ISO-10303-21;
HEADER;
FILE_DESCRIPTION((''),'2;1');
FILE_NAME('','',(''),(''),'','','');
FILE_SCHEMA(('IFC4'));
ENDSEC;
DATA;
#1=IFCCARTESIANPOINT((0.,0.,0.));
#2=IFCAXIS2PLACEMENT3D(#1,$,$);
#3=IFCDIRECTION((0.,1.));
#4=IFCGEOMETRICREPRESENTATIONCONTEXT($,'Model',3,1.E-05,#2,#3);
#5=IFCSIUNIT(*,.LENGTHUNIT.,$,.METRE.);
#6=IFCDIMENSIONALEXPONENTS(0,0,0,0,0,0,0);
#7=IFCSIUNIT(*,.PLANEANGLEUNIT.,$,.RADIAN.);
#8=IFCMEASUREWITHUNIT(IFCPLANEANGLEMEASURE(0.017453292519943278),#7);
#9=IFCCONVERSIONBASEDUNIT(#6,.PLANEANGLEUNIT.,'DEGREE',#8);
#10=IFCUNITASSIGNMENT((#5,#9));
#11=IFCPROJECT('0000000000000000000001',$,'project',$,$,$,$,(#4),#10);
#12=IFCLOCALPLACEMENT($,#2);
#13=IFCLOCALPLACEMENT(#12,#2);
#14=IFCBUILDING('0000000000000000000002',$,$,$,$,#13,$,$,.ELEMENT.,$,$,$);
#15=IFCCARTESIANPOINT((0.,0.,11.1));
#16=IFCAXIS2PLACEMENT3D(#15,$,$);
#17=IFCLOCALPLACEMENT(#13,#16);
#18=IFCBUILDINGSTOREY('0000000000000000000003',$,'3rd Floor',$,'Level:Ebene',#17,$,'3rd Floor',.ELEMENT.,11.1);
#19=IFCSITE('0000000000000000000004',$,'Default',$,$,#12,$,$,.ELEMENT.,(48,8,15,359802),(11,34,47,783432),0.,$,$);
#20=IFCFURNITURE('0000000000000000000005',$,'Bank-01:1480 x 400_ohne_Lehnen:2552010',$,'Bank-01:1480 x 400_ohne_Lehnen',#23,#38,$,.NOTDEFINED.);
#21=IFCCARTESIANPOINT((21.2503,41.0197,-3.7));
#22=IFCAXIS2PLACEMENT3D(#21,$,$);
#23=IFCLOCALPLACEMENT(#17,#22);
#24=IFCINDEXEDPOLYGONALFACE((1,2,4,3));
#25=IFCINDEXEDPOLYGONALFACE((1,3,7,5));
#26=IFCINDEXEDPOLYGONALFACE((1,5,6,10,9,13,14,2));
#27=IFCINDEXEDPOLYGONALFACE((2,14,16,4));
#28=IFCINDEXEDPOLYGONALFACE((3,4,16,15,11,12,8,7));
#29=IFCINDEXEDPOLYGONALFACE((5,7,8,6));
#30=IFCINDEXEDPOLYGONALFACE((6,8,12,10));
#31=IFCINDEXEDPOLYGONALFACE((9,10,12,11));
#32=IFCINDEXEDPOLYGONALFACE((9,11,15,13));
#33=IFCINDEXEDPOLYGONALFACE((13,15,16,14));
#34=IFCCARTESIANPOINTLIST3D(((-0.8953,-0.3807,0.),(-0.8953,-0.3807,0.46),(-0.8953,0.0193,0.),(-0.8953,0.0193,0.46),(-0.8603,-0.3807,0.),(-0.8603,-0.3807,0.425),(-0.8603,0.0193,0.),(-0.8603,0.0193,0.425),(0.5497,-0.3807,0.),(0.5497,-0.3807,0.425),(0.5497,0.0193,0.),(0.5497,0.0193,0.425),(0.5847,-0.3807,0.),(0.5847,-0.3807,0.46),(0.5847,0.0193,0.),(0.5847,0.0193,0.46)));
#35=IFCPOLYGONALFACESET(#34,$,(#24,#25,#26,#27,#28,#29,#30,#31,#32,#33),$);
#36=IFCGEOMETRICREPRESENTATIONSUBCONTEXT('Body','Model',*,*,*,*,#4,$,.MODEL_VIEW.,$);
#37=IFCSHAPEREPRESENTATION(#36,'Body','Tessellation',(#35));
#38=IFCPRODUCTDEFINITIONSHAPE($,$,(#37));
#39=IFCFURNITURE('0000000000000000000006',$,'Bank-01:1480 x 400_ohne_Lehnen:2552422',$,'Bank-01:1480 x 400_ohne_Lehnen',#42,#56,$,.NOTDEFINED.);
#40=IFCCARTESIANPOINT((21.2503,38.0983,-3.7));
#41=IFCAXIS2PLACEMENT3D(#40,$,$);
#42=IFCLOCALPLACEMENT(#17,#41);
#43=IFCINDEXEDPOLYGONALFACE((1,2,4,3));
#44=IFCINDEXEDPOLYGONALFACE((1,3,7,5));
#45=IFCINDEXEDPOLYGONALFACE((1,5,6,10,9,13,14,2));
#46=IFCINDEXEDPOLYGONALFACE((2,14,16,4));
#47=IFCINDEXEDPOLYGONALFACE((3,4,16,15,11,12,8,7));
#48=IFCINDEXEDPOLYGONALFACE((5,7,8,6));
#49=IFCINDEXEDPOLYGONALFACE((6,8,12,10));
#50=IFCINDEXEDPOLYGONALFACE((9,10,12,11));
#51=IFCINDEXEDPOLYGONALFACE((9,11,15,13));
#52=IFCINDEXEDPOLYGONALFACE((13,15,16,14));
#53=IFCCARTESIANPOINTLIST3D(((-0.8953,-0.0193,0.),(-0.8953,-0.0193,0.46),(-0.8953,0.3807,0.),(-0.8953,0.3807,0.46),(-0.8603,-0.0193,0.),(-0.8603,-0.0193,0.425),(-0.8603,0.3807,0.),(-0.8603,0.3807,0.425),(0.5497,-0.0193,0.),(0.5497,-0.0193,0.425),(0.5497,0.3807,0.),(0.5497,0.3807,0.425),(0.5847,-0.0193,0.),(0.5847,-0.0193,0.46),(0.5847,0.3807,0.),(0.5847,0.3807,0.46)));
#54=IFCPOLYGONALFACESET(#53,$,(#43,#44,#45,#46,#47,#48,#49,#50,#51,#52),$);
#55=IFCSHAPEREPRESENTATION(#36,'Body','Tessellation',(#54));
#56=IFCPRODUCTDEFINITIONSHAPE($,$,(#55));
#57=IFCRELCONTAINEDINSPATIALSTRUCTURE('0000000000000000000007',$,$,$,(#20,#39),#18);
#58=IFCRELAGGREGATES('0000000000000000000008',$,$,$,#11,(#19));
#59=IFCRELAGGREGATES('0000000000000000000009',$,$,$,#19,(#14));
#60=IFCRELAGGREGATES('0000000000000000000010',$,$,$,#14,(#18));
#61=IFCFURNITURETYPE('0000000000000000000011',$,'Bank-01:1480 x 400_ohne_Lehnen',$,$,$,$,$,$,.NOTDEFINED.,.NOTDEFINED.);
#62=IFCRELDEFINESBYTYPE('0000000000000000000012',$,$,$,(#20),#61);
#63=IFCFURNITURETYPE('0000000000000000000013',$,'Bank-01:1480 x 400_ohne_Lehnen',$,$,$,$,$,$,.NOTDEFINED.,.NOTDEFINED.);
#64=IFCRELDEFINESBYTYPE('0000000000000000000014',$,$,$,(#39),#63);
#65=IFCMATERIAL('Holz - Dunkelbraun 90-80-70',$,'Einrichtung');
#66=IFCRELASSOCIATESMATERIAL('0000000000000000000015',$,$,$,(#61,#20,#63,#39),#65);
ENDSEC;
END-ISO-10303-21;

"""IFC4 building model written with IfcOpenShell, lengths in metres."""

from ifc_helpers import new_model, entity, si_unit, converted_unit, direction, frame, origin, place, context, subcontext, project, spatial, indexed_curve, outline, extrude, source, transform, mapped, material, type_object, type_shapes, element, save


model = new_model("IFC4")

# Units and contexts
model_context = context("Model", 3, precision=1e-05, world=origin(), true_north=direction((0.0, 1.0)))
body_context = subcontext(model_context, "Body", "Model", "MODEL_VIEW")
ifc_project = project(units=[si_unit("LENGTHUNIT", "METRE"), converted_unit("PLANEANGLEUNIT", "DEGREE", entity("IfcPlaneAngleMeasure", 0.017453292519943278), si_unit("PLANEANGLEUNIT", "RADIAN"), dimensions=[0, 0, 0, 0, 0, 0, 0])], contexts=[model_context])

# Site, building, storey
site_placement = place(None, origin())
site = spatial("IfcSite", under=ifc_project, at=site_placement, Name="Default", CompositionType="ELEMENT", RefLatitude=(48, 8, 15, 359802), RefLongitude=(11, 34, 47, 783432), RefElevation=0.0)
building_placement = place(site_placement, origin())
building = spatial("IfcBuilding", under=site, at=building_placement, CompositionType="ELEMENT")
storey_placement = place(building_placement, frame((0.0, 0.0, 11.1)))
storey = spatial("IfcBuildingStorey", under=building, at=storey_placement, Name="3rd Floor", ObjectType="Level:Ebene", LongName="3rd Floor", CompositionType="ELEMENT", Elevation=11.1)

# Furniture
ifc_material_1 = material(Name="Holz - Dunkelbraun 90-80-70", Category="Einrichtung")
furniture_type_1 = type_object("IfcFurnitureType", Name="Bank-01:1480 x 400_ohne_Lehnen", AssemblyPlace="NOTDEFINED", PredefinedType="NOTDEFINED", material=ifc_material_1)
shared_shape_1 = source(origin(), body_context, "Body", "SweptSolid", [
    extrude(outline(indexed_curve([(-0.74, -0.2387), (0.74, -0.2387), (0.74, 0.2213), (0.705, 0.2213), (0.705, -0.2038), (-0.705, -0.2038), (-0.705, 0.2213), (-0.74, 0.2213), (-0.74, -0.2387)], self_intersect=False)), frame((-0.1553, -0.3807, 0.2213), z_axis=(0.0, 1.0, 0.0), x_axis=(1.0, 0.0, 0.0)), (0.0, 0.0, 1.0), 0.4),
])
type_shapes(furniture_type_1, [shared_shape_1])
furniture_1_placement = place(storey_placement, frame((21.2503, 41.0197, -3.7)))
element("IfcFurniture", 1, at=furniture_1_placement, inside=storey, type_object=furniture_type_1, material=ifc_material_1, Name="Bank-01:1480 x 400_ohne_Lehnen:2552010", ObjectType="Bank-01:1480 x 400_ohne_Lehnen", PredefinedType="NOTDEFINED", context=body_context, shape_type="MappedRepresentation", body=[
    mapped(shared_shape_1, transform((0.0, 0.0, 0.0), scale=1.0)),
])
furniture_type_2 = type_object("IfcFurnitureType", Name="Bank-01:1480 x 400_ohne_Lehnen", AssemblyPlace="NOTDEFINED", PredefinedType="NOTDEFINED", material=ifc_material_1)
shared_shape_2 = source(origin(), body_context, "Body", "SweptSolid", [
    extrude(outline(indexed_curve([(-0.74, -0.2387), (0.74, -0.2387), (0.74, 0.2213), (0.705, 0.2213), (0.705, -0.2038), (-0.705, -0.2038), (-0.705, 0.2213), (-0.74, 0.2213), (-0.74, -0.2387)], self_intersect=False)), frame((-0.1553, -0.0193, 0.2213), z_axis=(0.0, 1.0, 0.0), x_axis=(1.0, 0.0, 0.0)), (0.0, 0.0, 1.0), 0.4),
])
type_shapes(furniture_type_2, [shared_shape_2])
furniture_2_placement = place(storey_placement, frame((21.2503, 38.0983, -3.7)))
element("IfcFurniture", 2, at=furniture_2_placement, inside=storey, type_object=furniture_type_2, material=ifc_material_1, Name="Bank-01:1480 x 400_ohne_Lehnen:2552422", ObjectType="Bank-01:1480 x 400_ohne_Lehnen", PredefinedType="NOTDEFINED", context=body_context, shape_type="MappedRepresentation", body=[
    mapped(shared_shape_2, transform((0.0, 0.0, 0.0), scale=1.0)),
])

save(model, "model.ifc")
